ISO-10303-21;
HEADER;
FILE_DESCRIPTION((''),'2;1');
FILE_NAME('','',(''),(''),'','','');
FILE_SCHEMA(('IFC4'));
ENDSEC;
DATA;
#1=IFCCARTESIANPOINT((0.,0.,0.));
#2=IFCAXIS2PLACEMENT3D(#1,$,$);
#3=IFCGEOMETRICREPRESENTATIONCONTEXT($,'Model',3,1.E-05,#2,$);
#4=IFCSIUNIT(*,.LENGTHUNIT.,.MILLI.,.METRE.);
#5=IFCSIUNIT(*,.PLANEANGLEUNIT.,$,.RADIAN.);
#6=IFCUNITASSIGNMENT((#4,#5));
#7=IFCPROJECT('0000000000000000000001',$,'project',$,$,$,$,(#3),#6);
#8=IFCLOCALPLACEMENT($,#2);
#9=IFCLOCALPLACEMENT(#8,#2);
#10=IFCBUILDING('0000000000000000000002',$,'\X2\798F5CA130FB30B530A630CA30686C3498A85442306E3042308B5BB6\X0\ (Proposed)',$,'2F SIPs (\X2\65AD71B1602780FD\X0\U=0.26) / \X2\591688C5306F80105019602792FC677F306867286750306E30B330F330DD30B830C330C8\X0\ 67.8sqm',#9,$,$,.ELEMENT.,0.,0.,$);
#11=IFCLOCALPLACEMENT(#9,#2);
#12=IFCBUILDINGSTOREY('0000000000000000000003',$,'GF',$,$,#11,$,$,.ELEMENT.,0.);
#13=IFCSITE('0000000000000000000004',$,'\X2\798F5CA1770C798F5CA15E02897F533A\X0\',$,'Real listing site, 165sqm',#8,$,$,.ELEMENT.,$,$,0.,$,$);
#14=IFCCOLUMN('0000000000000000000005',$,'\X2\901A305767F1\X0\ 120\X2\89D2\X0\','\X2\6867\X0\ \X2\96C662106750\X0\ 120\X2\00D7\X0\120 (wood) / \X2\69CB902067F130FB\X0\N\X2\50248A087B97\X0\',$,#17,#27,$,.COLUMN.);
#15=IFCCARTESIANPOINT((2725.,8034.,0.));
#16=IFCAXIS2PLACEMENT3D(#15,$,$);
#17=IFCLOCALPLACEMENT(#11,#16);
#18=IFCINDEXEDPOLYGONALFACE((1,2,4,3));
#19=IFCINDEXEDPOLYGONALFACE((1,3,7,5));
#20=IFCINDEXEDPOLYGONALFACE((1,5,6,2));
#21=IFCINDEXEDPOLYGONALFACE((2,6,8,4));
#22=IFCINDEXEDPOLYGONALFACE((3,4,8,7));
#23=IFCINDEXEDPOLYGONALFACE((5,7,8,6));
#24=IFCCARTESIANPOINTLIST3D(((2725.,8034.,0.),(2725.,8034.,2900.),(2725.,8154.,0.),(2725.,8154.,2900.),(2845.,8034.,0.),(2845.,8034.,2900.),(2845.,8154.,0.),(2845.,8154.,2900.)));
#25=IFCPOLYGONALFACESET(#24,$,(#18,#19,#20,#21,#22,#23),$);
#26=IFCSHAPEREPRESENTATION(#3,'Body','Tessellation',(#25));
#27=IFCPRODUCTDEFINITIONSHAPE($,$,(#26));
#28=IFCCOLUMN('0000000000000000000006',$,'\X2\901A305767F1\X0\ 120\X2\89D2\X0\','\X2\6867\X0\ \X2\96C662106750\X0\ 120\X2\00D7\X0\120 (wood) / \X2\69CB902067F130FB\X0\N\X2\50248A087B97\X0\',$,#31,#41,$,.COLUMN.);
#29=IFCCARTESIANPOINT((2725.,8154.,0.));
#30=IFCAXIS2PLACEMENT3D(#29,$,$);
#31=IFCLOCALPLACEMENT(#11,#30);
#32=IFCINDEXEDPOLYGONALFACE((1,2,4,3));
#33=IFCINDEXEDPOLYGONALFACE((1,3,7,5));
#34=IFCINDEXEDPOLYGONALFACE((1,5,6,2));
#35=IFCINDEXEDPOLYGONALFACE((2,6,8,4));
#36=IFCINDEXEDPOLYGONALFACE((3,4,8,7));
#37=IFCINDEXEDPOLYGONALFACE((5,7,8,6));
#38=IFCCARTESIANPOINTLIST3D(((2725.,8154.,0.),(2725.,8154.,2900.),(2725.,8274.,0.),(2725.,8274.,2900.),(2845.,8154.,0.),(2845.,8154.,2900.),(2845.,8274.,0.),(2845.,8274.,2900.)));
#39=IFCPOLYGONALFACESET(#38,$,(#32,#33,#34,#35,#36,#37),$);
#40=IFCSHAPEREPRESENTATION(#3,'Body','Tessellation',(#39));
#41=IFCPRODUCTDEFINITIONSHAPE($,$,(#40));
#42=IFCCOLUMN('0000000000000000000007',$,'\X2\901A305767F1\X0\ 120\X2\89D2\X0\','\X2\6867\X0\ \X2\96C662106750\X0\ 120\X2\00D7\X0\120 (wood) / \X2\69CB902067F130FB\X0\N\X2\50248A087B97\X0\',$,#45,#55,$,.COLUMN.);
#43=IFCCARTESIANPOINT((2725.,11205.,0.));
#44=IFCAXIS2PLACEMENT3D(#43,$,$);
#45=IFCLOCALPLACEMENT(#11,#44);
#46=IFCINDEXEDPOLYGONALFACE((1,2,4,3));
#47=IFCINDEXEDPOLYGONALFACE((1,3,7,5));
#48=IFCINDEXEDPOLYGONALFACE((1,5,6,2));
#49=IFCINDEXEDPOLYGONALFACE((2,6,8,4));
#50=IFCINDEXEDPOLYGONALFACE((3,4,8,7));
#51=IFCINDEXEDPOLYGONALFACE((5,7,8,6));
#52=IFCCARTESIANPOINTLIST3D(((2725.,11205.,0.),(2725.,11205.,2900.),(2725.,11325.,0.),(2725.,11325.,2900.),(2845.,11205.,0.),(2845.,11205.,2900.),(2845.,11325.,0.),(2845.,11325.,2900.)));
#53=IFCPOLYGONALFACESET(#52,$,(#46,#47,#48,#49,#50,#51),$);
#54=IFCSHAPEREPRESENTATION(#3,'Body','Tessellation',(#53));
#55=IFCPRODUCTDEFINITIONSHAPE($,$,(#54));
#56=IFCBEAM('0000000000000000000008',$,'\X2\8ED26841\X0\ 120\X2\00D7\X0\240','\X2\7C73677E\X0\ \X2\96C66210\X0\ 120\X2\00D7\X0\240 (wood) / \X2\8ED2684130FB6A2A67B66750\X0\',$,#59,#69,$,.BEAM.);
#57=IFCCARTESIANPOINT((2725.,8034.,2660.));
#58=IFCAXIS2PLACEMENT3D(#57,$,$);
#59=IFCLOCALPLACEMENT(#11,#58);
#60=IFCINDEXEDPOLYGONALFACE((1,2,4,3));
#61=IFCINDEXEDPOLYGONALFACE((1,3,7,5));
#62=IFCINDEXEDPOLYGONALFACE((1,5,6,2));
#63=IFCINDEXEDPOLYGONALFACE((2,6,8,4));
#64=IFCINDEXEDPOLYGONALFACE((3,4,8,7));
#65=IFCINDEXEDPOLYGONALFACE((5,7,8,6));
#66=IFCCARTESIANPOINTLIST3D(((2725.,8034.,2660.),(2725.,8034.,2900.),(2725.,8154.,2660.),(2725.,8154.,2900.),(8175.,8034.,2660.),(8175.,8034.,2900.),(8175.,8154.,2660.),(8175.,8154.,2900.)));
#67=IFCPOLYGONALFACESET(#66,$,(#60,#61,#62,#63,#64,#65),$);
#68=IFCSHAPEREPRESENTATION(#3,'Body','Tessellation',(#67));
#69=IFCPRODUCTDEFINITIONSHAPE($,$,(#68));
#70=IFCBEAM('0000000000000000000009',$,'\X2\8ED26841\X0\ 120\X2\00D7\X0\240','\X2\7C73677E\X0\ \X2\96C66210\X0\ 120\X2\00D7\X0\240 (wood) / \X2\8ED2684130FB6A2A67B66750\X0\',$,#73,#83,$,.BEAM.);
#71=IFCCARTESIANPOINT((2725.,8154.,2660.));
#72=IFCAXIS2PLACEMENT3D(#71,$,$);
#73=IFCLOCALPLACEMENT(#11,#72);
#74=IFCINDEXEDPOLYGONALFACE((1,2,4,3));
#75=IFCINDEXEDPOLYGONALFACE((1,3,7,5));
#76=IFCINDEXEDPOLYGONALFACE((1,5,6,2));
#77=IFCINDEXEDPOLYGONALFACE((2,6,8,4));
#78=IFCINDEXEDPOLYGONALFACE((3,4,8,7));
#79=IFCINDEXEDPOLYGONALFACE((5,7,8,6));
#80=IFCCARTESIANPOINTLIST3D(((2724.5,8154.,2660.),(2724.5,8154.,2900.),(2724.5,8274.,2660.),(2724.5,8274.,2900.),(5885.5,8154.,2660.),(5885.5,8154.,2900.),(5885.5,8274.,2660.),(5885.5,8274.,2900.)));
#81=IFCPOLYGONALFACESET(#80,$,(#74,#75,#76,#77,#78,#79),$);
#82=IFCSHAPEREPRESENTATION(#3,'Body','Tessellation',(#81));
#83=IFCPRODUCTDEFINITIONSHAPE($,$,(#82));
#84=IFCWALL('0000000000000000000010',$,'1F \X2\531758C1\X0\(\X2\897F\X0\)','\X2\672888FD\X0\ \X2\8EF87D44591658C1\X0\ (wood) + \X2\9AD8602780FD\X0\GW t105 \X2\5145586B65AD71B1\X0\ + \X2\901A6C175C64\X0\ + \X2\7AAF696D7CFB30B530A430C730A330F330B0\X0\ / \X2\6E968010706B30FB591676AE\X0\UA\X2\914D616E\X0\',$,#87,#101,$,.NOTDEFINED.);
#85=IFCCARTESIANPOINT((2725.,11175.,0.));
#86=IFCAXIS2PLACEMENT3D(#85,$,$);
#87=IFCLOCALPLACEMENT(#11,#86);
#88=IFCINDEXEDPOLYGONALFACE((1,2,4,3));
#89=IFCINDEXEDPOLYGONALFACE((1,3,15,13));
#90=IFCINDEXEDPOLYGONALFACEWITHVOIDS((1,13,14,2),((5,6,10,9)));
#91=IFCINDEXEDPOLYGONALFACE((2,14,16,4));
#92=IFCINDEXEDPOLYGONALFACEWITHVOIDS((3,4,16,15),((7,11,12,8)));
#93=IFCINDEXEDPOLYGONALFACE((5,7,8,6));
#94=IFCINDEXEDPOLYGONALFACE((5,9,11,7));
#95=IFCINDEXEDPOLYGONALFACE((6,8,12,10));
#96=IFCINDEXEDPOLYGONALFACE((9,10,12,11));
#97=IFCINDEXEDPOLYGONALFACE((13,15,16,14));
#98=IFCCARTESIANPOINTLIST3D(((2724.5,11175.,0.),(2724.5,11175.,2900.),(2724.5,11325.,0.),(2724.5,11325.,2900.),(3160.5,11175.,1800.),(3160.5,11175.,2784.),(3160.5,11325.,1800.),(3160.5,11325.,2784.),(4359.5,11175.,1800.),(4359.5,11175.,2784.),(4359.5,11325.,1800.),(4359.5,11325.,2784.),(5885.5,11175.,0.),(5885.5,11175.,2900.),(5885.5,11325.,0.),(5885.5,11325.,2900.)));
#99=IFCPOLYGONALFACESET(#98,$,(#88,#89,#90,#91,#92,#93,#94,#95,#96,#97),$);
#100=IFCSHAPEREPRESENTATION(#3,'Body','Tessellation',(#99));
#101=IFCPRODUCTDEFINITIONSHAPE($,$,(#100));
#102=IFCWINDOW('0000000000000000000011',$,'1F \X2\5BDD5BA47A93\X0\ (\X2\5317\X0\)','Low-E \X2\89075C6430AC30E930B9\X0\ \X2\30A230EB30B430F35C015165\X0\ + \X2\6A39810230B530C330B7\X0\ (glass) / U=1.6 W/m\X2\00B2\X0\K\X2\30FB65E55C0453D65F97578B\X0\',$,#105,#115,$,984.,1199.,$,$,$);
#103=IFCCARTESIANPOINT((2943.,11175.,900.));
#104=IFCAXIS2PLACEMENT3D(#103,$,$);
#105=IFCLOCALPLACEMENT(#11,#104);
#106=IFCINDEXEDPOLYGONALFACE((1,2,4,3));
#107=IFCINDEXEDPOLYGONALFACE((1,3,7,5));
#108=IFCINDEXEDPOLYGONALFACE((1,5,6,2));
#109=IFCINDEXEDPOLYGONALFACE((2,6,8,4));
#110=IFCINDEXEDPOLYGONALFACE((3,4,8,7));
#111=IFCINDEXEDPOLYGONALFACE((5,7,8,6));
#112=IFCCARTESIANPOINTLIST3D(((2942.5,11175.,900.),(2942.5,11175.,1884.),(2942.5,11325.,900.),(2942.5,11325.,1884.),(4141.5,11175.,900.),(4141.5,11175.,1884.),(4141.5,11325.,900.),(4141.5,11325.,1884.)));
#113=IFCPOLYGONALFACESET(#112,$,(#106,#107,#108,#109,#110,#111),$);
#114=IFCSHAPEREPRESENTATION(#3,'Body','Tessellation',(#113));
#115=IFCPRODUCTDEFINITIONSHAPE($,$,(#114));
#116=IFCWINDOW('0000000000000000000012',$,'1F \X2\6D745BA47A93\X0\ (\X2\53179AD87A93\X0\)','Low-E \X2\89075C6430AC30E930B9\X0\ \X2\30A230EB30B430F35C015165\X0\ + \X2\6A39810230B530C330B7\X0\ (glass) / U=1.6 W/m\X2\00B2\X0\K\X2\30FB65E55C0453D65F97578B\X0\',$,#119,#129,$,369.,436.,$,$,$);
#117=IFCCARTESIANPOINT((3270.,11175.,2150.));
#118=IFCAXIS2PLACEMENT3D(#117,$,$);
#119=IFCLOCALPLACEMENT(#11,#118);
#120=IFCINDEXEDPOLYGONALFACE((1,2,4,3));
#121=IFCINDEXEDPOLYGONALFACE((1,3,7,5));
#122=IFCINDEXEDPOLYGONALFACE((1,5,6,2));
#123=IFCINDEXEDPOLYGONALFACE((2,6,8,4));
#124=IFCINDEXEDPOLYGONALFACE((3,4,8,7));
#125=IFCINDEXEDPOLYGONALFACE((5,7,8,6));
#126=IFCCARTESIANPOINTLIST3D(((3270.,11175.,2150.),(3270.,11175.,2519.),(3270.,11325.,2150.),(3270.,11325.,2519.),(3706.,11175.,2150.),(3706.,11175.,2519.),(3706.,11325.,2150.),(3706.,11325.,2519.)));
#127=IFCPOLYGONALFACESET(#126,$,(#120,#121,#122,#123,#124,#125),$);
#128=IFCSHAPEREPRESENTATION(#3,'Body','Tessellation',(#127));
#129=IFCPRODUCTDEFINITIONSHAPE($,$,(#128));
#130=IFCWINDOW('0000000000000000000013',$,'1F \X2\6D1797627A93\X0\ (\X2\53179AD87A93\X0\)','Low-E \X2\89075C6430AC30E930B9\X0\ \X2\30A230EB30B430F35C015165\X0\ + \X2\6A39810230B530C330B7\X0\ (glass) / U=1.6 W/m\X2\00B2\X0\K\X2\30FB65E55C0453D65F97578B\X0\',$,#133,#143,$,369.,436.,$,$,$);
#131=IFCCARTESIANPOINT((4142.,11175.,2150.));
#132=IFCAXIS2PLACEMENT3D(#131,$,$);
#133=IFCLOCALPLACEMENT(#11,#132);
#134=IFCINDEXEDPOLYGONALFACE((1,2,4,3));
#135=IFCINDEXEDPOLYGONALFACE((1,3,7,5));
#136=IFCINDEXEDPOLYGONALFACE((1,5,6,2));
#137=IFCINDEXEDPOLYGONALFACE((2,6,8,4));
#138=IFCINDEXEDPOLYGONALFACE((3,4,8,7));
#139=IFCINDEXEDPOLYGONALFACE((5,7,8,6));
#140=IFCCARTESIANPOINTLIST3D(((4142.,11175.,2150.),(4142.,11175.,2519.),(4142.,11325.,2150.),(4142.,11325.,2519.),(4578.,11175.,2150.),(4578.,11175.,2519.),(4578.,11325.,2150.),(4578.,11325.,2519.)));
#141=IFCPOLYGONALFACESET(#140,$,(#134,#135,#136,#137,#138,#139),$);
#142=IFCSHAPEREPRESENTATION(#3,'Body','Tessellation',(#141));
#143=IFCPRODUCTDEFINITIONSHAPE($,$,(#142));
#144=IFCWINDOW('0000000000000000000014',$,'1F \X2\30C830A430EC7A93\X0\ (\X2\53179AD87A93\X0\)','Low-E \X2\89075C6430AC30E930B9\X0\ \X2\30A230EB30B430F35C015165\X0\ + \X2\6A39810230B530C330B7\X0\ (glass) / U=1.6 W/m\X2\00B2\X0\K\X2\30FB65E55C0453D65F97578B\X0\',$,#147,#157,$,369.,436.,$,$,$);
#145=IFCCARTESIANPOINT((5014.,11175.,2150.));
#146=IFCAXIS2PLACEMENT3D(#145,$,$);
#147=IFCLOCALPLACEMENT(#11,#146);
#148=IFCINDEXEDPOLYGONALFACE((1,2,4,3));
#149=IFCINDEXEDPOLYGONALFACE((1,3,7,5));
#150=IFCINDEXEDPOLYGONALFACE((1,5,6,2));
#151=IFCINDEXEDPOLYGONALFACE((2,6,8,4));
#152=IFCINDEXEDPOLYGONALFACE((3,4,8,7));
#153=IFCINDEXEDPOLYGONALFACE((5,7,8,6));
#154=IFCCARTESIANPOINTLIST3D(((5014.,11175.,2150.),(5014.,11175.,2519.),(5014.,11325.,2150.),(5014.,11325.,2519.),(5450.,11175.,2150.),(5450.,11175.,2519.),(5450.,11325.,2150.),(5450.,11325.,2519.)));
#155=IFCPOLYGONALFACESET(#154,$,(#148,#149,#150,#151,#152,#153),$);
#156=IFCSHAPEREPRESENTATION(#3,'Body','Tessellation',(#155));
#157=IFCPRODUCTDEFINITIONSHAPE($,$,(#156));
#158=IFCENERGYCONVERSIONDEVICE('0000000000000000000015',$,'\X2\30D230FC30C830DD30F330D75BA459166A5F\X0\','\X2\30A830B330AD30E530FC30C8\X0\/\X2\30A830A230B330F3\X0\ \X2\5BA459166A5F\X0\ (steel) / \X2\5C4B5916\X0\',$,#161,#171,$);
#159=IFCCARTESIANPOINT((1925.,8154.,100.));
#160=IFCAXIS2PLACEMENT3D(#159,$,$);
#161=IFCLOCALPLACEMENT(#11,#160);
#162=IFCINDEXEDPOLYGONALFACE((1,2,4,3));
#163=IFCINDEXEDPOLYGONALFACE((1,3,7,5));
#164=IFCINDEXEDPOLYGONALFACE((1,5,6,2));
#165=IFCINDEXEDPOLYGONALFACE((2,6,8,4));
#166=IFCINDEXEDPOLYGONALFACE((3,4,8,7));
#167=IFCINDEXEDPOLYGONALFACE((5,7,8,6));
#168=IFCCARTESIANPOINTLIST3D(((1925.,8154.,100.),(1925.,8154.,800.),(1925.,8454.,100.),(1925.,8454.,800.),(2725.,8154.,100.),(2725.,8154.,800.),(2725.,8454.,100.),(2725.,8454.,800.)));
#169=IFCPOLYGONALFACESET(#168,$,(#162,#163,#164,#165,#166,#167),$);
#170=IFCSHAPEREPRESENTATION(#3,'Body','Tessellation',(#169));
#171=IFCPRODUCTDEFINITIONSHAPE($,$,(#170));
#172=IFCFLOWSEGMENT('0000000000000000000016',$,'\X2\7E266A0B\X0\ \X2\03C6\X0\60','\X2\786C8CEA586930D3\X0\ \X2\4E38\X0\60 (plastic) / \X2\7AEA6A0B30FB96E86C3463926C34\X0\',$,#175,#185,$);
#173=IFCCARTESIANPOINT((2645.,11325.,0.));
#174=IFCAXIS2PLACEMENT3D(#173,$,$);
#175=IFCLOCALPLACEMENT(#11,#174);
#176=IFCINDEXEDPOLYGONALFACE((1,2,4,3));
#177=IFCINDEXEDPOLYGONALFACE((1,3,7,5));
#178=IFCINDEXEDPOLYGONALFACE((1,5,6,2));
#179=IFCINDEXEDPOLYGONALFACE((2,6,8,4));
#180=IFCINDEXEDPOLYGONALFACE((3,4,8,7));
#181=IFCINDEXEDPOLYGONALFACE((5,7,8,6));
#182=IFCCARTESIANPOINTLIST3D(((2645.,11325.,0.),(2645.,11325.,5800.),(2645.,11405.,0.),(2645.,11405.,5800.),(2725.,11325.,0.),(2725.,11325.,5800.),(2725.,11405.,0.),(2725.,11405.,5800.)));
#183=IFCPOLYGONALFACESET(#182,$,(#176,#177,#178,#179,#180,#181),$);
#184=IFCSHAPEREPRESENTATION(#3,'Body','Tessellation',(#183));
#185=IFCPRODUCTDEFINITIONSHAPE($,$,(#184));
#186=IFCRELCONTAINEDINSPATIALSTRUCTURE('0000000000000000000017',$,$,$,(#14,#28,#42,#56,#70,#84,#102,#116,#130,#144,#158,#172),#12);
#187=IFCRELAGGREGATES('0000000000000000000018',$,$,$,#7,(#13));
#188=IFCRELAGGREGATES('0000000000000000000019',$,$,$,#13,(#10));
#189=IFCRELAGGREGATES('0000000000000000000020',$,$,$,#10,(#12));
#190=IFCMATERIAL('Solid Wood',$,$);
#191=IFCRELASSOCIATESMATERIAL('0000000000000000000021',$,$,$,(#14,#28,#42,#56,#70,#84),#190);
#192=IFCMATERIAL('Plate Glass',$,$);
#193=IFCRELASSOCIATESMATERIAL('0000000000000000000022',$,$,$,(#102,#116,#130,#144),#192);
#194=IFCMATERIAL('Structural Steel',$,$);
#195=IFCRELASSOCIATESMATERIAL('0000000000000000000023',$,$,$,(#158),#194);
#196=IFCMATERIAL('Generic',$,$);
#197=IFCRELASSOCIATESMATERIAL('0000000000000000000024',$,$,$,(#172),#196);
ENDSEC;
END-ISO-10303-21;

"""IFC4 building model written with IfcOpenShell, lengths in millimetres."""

from ifc_helpers import new_model, si_unit, frame, frame_2d, origin, place, context, project, spatial, rectangle, extrude, material, element, fill, save


model = new_model("IFC4")

# Units and contexts
model_context = context("Model", 3, precision=1e-05, world=origin())
ifc_project = project(units=[si_unit("LENGTHUNIT", "METRE", prefix="MILLI"), si_unit("PLANEANGLEUNIT", "RADIAN")], contexts=[model_context])

# Site, building, storey
site_placement = place(None, origin())
site = spatial("IfcSite", under=ifc_project, at=site_placement, Name="福岡県福岡市西区", ObjectType="Real listing site, 165sqm", CompositionType="ELEMENT", RefElevation=0.0)
building_placement = place(site_placement, origin())
building = spatial("IfcBuilding", under=site, at=building_placement, Name="福岡・サウナと水風呂のある家 (Proposed)", ObjectType="2F SIPs (断熱性能U=0.26) / 外装は耐候性鋼板と木材のコンポジット 67.8sqm", CompositionType="ELEMENT", ElevationOfRefHeight=0.0, ElevationOfTerrain=0.0)
storey_placement = place(building_placement, origin())
storey = spatial("IfcBuildingStorey", under=building, at=storey_placement, Name="GF", CompositionType="ELEMENT", Elevation=0.0)

# Columns
ifc_material_1 = material(Name="Solid Wood")
column_1_placement = place(storey_placement, frame((2725.0, 8034.0, 0.0)))
element("IfcColumn", 1, at=column_1_placement, inside=storey, material=ifc_material_1, Name="通し柱 120角", Description="桧 集成材 120×120 (wood) / 構造柱・N値計算", PredefinedType="COLUMN", context=model_context, shape_type="SweptSolid", body=[
    extrude(rectangle(XDim=120.0, YDim=120.0, at=frame_2d((60.0, 60.0))), frame((2725.0, 8034.0, 0.0)), (0.0, 0.0, 1.0), 2900.0),
])
column_2_placement = place(storey_placement, frame((2725.0, 8154.0, 0.0)))
element("IfcColumn", 2, at=column_2_placement, inside=storey, material=ifc_material_1, Name="通し柱 120角", Description="桧 集成材 120×120 (wood) / 構造柱・N値計算", PredefinedType="COLUMN", context=model_context, shape_type="SweptSolid", body=[
    extrude(rectangle(XDim=120.0, YDim=120.0, at=frame_2d((60.0, 60.0))), frame((2725.0, 8154.0, 0.0)), (0.0, 0.0, 1.0), 2900.0),
])
column_3_placement = place(storey_placement, frame((2725.0, 11205.0, 0.0)))
element("IfcColumn", 3, at=column_3_placement, inside=storey, material=ifc_material_1, Name="通し柱 120角", Description="桧 集成材 120×120 (wood) / 構造柱・N値計算", PredefinedType="COLUMN", context=model_context, shape_type="SweptSolid", body=[
    extrude(rectangle(XDim=120.0, YDim=120.0, at=frame_2d((60.0, 60.0))), frame((2725.0, 11205.0, 0.0)), (0.0, 0.0, 1.0), 2900.0),
])

# Beams
beam_1_placement = place(storey_placement, frame((2725.0, 8034.0, 2660.0)))
element("IfcBeam", 4, at=beam_1_placement, inside=storey, material=ifc_material_1, Name="軒桁 120×240", Description="米松 集成 120×240 (wood) / 軒桁・横架材", PredefinedType="BEAM", context=model_context, shape_type="SweptSolid", body=[
    extrude(rectangle(XDim=5450.0, YDim=120.0, at=frame_2d((2725.0, 60.0))), frame((2725.0, 8034.0, 2660.0)), (0.0, 0.0, 1.0), 240.0),
])
beam_2_placement = place(storey_placement, frame((2725.0, 8154.0, 2660.0)))
element("IfcBeam", 5, at=beam_2_placement, inside=storey, material=ifc_material_1, Name="軒桁 120×240", Description="米松 集成 120×240 (wood) / 軒桁・横架材", PredefinedType="BEAM", context=model_context, shape_type="SweptSolid", body=[
    extrude(rectangle(XDim=3161.0, YDim=120.0, at=frame_2d((1580.0, 60.0))), frame((2725.0, 8154.0, 2660.0)), (0.0, 0.0, 1.0), 240.0),
])

# Wall, openings, windows
wall_1_placement = place(storey_placement, frame((2725.0, 11175.0, 0.0)))
wall_1 = element("IfcWall", 6, at=wall_1_placement, inside=storey, material=ifc_material_1, Name="1F 北壁(西)", Description="木製 軸組外壁 (wood) + 高性能GW t105 充填断熱 + 通気層 + 窯業系サイディング / 準耐火・外皮UA配慮", PredefinedType="NOTDEFINED", context=model_context, shape_type="SweptSolid", body=[
    extrude(rectangle(XDim=3161.0, YDim=150.0, at=frame_2d((1580.0, 75.0))), frame((2725.0, 11175.0, 0.0)), (0.0, 0.0, 1.0), 2900.0),
])
opening_1_placement = place(storey_placement, frame((2943.0, 11175.0, 900.0)))
opening_1 = element("IfcOpeningElement", 7, at=opening_1_placement, cuts=wall_1, PredefinedType="NOTDEFINED", context=model_context, shape_type="SweptSolid", body=[
    extrude(rectangle(XDim=1199.0, YDim=150.0, at=frame_2d((599.0, 75.0))), frame((2943.0, 11175.0, 900.0)), (0.0, 0.0, 1.0), 984.0),
])
opening_2_placement = place(storey_placement, frame((3270.0, 11175.0, 2150.0)))
opening_2 = element("IfcOpeningElement", 8, at=opening_2_placement, cuts=wall_1, PredefinedType="NOTDEFINED", context=model_context, shape_type="SweptSolid", body=[
    extrude(rectangle(XDim=436.0, YDim=150.0, at=frame_2d((218.0, 75.0))), frame((3270.0, 11175.0, 2150.0)), (0.0, 0.0, 1.0), 369.0),
])
opening_3_placement = place(storey_placement, frame((4142.0, 11175.0, 2150.0)))
opening_3 = element("IfcOpeningElement", 9, at=opening_3_placement, cuts=wall_1, PredefinedType="NOTDEFINED", context=model_context, shape_type="SweptSolid", body=[
    extrude(rectangle(XDim=436.0, YDim=150.0, at=frame_2d((218.0, 75.0))), frame((4142.0, 11175.0, 2150.0)), (0.0, 0.0, 1.0), 369.0),
])
opening_4_placement = place(storey_placement, frame((5014.0, 11175.0, 2150.0)))
opening_4 = element("IfcOpeningElement", 10, at=opening_4_placement, cuts=wall_1, PredefinedType="NOTDEFINED", context=model_context, shape_type="SweptSolid", body=[
    extrude(rectangle(XDim=436.0, YDim=150.0, at=frame_2d((218.0, 75.0))), frame((5014.0, 11175.0, 2150.0)), (0.0, 0.0, 1.0), 369.0),
])
ifc_material_2 = material(Name="Plate Glass")
window_1_placement = place(storey_placement, frame((2943.0, 11175.0, 900.0)))
window_1 = element("IfcWindow", 11, at=window_1_placement, inside=storey, material=ifc_material_2, Name="1F 寝室窓 (北)", Description="Low-E 複層ガラス アルゴン封入 + 樹脂サッシ (glass) / U=1.6 W/m²K・日射取得型", OverallHeight=984.0, OverallWidth=1199.0, context=model_context, shape_type="SweptSolid", body=[
    extrude(rectangle(XDim=1199.0, YDim=150.0, at=frame_2d((599.0, 75.0))), frame((2943.0, 11175.0, 900.0)), (0.0, 0.0, 1.0), 984.0),
])
fill(opening_1, window_1)
window_2_placement = place(storey_placement, frame((3270.0, 11175.0, 2150.0)))
window_2 = element("IfcWindow", 12, at=window_2_placement, inside=storey, material=ifc_material_2, Name="1F 浴室窓 (北高窓)", Description="Low-E 複層ガラス アルゴン封入 + 樹脂サッシ (glass) / U=1.6 W/m²K・日射取得型", OverallHeight=369.0, OverallWidth=436.0, context=model_context, shape_type="SweptSolid", body=[
    extrude(rectangle(XDim=436.0, YDim=150.0, at=frame_2d((218.0, 75.0))), frame((3270.0, 11175.0, 2150.0)), (0.0, 0.0, 1.0), 369.0),
])
fill(opening_2, window_2)
window_3_placement = place(storey_placement, frame((4142.0, 11175.0, 2150.0)))
window_3 = element("IfcWindow", 13, at=window_3_placement, inside=storey, material=ifc_material_2, Name="1F 洗面窓 (北高窓)", Description="Low-E 複層ガラス アルゴン封入 + 樹脂サッシ (glass) / U=1.6 W/m²K・日射取得型", OverallHeight=369.0, OverallWidth=436.0, context=model_context, shape_type="SweptSolid", body=[
    extrude(rectangle(XDim=436.0, YDim=150.0, at=frame_2d((218.0, 75.0))), frame((4142.0, 11175.0, 2150.0)), (0.0, 0.0, 1.0), 369.0),
])
fill(opening_3, window_3)
window_4_placement = place(storey_placement, frame((5014.0, 11175.0, 2150.0)))
window_4 = element("IfcWindow", 14, at=window_4_placement, inside=storey, material=ifc_material_2, Name="1F トイレ窓 (北高窓)", Description="Low-E 複層ガラス アルゴン封入 + 樹脂サッシ (glass) / U=1.6 W/m²K・日射取得型", OverallHeight=369.0, OverallWidth=436.0, context=model_context, shape_type="SweptSolid", body=[
    extrude(rectangle(XDim=436.0, YDim=150.0, at=frame_2d((218.0, 75.0))), frame((5014.0, 11175.0, 2150.0)), (0.0, 0.0, 1.0), 369.0),
])
fill(opening_4, window_4)

# Shared definitions
ifc_material_3 = material(Name="Generic")

# Energy conversion device
ifc_material_4 = material(Name="Structural Steel")
energy_conversion_device_placement = place(storey_placement, frame((1925.0, 8154.0, 100.0)))
element("IfcEnergyConversionDevice", 15, at=energy_conversion_device_placement, inside=storey, material=ifc_material_4, Name="ヒートポンプ室外機", Description="エコキュート/エアコン 室外機 (steel) / 屋外", context=model_context, shape_type="SweptSolid", body=[
    extrude(rectangle(XDim=800.0, YDim=300.0, at=frame_2d((400.0, 150.0))), frame((1925.0, 8154.0, 100.0)), (0.0, 0.0, 1.0), 700.0),
])

# Flow segment
flow_segment_placement = place(storey_placement, frame((2645.0, 11325.0, 0.0)))
element("IfcFlowSegment", 16, at=flow_segment_placement, inside=storey, material=ifc_material_3, Name="縦樋 φ60", Description="硬質塩ビ 丸60 (plastic) / 竪樋・雨水排水", context=model_context, shape_type="SweptSolid", body=[
    extrude(rectangle(XDim=80.0, YDim=80.0, at=frame_2d((40.0, 40.0))), frame((2645.0, 11325.0, 0.0)), (0.0, 0.0, 1.0), 5800.0),
])

save(model, "model.ifc")
